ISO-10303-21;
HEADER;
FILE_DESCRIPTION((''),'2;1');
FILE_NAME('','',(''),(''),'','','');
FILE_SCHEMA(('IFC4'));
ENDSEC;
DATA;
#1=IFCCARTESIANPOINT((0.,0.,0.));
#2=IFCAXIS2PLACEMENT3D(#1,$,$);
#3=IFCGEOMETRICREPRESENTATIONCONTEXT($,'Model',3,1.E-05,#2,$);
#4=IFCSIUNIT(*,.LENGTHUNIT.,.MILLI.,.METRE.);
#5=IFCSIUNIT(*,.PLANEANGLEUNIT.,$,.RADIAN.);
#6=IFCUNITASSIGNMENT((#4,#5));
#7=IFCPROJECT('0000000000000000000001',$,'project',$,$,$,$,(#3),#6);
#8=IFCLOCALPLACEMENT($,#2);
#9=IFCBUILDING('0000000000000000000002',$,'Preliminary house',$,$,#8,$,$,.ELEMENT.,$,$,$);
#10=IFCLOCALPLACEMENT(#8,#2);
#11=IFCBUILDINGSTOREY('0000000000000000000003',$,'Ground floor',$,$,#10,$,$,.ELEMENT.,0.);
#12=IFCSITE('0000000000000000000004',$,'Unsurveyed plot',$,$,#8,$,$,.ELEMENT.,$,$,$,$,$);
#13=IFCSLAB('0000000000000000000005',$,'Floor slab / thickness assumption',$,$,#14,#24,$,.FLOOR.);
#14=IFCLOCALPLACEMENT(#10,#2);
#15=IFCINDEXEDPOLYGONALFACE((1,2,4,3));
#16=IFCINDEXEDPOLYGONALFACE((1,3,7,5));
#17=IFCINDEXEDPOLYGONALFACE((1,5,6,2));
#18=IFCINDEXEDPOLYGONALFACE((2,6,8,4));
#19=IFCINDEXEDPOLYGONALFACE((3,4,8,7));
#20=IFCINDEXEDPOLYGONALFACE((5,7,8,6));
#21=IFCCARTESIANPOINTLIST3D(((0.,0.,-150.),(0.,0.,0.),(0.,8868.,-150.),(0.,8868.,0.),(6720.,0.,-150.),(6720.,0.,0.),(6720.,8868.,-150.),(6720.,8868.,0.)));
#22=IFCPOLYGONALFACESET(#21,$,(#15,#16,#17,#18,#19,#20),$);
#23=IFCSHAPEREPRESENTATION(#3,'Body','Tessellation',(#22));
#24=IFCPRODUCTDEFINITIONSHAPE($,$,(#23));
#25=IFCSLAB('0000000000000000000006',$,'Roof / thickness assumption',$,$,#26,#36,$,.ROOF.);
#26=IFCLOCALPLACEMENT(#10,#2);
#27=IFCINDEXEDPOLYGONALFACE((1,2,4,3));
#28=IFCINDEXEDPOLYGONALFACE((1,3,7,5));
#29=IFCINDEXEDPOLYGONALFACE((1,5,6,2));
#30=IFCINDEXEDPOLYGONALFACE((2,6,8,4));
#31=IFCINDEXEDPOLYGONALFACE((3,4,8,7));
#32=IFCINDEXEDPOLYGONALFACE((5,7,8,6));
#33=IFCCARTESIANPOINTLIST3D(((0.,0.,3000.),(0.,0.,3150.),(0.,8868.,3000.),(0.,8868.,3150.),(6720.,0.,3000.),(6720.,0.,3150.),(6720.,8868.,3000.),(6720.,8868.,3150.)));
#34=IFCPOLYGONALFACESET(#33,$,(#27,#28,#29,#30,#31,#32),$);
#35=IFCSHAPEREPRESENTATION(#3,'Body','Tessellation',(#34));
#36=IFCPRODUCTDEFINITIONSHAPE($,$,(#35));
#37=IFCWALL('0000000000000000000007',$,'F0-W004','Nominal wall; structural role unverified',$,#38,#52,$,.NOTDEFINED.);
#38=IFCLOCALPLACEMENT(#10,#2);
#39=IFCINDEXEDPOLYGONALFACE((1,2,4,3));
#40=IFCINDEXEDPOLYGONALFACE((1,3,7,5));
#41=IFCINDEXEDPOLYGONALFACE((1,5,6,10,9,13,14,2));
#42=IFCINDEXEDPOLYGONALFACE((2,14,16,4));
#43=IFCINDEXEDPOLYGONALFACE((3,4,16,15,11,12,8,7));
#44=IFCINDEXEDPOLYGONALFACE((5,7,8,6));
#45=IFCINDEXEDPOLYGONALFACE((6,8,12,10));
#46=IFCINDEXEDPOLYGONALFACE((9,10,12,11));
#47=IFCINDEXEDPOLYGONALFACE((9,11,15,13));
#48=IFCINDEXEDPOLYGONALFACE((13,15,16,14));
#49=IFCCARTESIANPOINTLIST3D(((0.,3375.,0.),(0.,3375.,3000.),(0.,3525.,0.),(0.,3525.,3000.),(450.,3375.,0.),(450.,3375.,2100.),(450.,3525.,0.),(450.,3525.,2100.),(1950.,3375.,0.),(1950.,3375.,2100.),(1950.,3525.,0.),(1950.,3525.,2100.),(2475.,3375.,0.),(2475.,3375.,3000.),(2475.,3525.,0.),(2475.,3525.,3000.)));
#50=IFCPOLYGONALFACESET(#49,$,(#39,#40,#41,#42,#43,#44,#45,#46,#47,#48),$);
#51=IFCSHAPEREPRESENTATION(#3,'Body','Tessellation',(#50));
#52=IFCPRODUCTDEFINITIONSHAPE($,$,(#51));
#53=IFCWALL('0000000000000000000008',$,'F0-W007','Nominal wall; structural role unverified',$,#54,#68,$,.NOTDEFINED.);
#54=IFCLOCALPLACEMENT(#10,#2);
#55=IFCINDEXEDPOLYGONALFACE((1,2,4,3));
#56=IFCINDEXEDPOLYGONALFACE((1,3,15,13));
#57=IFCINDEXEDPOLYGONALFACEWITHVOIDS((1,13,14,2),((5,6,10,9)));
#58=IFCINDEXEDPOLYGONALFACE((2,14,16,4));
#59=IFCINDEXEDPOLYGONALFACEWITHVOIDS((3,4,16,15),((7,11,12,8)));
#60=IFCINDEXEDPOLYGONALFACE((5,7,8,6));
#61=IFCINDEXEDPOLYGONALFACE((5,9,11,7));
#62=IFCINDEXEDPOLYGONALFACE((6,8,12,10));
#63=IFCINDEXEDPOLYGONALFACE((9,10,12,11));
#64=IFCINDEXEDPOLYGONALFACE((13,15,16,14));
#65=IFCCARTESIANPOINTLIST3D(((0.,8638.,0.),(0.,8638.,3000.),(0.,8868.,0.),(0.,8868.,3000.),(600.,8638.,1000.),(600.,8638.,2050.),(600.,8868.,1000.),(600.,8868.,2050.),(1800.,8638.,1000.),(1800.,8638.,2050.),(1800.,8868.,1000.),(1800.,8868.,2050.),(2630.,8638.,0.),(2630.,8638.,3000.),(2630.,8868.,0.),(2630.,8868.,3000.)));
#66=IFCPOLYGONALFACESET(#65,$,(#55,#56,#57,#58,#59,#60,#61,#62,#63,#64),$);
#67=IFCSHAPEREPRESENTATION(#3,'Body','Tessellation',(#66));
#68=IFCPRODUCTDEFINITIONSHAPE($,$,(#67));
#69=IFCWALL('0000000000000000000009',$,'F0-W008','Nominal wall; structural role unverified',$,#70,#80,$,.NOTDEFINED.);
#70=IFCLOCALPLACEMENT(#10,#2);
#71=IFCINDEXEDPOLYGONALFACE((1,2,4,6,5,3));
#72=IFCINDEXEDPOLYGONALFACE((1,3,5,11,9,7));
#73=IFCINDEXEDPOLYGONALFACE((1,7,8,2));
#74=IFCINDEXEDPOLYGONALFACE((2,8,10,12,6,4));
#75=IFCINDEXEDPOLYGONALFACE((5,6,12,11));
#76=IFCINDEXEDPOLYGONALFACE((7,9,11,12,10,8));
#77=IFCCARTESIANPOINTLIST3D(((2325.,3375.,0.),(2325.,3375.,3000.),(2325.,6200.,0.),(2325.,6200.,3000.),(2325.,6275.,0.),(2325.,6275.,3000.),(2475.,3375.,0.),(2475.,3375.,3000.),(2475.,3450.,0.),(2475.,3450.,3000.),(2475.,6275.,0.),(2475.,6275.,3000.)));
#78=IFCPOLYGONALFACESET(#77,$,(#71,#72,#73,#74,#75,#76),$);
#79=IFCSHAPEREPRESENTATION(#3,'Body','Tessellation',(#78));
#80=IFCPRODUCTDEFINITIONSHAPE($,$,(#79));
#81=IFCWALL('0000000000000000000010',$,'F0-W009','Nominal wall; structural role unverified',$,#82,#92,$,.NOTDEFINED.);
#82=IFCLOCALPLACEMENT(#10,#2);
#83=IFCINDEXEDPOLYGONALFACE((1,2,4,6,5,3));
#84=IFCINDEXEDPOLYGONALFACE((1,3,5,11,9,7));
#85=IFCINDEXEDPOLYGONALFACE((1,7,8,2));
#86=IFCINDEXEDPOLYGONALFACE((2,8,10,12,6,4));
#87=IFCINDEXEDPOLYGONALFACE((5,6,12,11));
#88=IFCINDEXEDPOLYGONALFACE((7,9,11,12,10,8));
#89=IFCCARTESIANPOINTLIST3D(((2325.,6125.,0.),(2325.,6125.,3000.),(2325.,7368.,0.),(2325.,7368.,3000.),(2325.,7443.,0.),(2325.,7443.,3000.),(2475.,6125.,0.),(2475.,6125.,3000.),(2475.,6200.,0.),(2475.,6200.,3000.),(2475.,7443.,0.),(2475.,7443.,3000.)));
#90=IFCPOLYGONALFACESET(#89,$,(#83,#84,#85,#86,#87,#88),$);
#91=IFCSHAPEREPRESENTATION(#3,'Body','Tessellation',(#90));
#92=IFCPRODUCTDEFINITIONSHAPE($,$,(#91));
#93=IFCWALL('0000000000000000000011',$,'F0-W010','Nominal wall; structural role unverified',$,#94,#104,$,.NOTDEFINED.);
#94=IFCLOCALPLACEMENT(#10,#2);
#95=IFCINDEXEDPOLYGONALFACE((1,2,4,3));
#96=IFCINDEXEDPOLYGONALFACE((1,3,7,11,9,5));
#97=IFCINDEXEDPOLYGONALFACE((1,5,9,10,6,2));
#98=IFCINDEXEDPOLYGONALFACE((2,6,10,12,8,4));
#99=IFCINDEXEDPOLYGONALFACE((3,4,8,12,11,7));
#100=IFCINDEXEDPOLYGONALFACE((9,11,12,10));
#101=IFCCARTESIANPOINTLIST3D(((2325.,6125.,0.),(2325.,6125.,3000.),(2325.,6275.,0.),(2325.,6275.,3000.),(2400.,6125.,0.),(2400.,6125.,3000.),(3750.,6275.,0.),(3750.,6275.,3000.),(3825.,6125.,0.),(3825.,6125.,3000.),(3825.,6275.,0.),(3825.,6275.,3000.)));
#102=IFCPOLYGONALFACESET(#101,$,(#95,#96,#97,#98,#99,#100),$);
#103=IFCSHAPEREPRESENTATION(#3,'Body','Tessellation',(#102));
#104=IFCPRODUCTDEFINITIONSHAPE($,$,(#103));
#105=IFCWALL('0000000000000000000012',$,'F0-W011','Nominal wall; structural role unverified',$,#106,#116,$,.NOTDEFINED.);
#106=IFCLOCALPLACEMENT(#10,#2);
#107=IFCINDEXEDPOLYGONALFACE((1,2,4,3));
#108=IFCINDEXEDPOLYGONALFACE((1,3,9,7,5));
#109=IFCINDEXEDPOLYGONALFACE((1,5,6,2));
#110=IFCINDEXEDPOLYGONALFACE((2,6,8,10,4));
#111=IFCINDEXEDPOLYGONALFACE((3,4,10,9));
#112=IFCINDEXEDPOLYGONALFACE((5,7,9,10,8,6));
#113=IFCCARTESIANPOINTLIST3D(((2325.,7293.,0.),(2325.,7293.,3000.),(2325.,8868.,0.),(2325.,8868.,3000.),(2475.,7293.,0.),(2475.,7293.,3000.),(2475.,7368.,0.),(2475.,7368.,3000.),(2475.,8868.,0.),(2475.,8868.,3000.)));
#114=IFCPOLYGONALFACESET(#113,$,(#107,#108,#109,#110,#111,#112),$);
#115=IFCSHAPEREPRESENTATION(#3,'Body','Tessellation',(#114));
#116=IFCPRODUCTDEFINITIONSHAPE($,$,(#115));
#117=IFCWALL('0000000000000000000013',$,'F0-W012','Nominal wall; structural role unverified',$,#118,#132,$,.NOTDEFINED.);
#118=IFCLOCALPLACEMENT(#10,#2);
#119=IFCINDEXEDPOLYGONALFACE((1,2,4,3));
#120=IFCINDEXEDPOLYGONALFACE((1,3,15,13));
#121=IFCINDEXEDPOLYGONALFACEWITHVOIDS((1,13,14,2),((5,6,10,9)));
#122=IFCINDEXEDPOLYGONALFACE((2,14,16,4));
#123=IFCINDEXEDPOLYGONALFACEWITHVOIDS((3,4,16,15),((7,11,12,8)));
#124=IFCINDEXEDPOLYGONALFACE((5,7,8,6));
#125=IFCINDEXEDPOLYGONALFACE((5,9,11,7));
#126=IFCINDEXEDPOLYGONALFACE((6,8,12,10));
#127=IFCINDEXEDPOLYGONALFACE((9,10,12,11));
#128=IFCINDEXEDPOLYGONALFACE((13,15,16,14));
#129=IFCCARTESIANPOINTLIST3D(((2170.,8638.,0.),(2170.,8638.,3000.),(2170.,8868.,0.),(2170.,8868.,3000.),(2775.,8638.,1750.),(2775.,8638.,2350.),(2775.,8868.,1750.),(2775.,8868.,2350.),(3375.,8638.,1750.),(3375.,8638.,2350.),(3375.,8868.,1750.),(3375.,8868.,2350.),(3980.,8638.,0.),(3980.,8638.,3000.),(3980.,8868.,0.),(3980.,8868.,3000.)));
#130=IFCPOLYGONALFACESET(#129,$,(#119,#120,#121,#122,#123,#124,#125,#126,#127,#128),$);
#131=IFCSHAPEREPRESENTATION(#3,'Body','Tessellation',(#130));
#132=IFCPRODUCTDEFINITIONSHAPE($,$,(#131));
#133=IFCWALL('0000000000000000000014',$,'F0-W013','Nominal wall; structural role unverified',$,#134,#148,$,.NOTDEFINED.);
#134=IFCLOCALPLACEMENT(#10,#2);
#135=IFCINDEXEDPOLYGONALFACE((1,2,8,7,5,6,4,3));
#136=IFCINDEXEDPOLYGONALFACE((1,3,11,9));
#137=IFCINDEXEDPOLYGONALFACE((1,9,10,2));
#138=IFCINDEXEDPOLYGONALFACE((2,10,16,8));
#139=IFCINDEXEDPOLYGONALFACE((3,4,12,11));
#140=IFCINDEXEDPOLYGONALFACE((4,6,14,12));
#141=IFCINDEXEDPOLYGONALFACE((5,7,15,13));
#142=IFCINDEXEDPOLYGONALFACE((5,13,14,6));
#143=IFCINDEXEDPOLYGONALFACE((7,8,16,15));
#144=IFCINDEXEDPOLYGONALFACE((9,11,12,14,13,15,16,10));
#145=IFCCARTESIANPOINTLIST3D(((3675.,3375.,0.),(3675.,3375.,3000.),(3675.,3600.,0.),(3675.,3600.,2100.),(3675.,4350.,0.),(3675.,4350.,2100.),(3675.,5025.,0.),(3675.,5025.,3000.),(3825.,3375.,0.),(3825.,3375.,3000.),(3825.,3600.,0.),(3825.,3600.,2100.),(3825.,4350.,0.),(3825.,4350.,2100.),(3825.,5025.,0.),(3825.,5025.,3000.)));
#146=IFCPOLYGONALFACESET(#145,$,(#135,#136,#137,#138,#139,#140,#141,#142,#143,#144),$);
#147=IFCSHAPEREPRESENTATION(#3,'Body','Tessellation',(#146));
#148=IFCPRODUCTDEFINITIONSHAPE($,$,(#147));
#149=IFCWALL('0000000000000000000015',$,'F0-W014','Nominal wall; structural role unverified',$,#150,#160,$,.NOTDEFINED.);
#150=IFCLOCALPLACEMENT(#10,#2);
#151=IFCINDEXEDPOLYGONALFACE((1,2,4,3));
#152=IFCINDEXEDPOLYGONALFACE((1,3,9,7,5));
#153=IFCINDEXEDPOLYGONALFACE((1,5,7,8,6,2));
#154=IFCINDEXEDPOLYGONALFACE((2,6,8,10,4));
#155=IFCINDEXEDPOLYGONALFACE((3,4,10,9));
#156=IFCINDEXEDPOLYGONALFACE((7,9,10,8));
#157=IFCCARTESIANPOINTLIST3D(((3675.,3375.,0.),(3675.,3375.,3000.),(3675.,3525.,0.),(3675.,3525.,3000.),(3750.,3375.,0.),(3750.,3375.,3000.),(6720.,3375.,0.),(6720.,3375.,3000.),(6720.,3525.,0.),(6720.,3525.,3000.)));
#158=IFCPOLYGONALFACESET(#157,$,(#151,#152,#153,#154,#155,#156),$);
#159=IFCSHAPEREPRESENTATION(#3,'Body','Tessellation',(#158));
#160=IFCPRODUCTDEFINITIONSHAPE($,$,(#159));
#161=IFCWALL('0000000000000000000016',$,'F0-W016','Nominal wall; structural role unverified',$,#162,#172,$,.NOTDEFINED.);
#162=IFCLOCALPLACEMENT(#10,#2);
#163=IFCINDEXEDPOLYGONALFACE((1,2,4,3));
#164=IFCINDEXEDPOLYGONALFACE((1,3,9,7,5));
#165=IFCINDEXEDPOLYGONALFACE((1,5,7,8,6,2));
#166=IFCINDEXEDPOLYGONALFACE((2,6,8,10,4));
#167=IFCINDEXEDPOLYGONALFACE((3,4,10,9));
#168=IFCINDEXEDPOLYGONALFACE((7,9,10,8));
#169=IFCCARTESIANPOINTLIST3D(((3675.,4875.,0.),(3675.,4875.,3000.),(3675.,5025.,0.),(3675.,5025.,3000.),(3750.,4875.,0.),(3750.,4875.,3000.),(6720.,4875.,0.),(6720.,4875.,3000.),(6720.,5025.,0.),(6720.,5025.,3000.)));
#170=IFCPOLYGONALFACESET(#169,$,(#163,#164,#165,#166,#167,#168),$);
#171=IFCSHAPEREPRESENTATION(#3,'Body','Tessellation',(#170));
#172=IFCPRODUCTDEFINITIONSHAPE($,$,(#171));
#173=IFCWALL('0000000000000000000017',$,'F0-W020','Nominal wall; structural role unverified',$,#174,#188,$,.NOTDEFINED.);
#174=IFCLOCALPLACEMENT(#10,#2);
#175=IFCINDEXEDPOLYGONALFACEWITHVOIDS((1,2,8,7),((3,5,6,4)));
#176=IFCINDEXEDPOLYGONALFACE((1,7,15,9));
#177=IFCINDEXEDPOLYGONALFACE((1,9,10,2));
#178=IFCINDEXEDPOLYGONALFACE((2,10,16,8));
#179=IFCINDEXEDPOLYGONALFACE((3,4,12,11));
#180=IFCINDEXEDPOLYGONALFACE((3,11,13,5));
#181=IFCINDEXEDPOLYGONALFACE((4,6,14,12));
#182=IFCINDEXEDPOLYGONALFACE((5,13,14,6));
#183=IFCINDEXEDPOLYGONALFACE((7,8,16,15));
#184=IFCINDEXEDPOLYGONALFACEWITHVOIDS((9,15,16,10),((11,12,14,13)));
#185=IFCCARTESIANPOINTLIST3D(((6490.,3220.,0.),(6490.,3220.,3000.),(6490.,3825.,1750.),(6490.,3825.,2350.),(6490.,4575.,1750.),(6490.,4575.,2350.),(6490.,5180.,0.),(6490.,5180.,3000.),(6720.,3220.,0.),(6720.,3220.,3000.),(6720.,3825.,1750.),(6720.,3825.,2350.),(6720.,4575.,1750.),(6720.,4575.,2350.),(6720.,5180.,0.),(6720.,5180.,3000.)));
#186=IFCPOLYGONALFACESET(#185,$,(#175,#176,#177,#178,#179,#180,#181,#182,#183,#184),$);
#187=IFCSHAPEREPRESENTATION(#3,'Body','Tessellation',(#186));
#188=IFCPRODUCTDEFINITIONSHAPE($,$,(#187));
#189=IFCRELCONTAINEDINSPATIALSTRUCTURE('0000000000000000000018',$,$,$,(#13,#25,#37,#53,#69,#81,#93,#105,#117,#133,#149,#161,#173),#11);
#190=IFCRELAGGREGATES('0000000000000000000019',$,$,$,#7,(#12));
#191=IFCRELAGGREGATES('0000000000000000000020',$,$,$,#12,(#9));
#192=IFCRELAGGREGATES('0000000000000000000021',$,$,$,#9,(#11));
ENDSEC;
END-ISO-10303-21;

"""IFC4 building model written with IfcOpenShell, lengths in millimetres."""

from ifc_helpers import new_model, si_unit, frame, origin, place, context, project, spatial, polyline, outline, extrude, element, save


model = new_model("IFC4")

# Units and contexts
model_context = context("Model", 3, precision=1e-05, world=origin())
ifc_project = project(units=[si_unit("LENGTHUNIT", "METRE", prefix="MILLI"), si_unit("PLANEANGLEUNIT", "RADIAN")], contexts=[model_context])

# Site, building, storey
placement_1 = place(None, origin())
site = spatial("IfcSite", under=ifc_project, at=placement_1, Name="Unsurveyed plot", CompositionType="ELEMENT")
building = spatial("IfcBuilding", under=site, at=placement_1, Name="Preliminary house", CompositionType="ELEMENT")
placement_2 = place(placement_1, origin())
storey = spatial("IfcBuildingStorey", under=building, at=placement_2, Name="Ground floor", CompositionType="ELEMENT", Elevation=0.0)

# Slabs
element("IfcSlab", 1, at=placement_2, inside=storey, Name="Floor slab / thickness assumption", PredefinedType="FLOOR", context=model_context, shape_type="SweptSolid", body=[
    extrude(outline(polyline([(6720.0, 0.0), (6720.0, 8868.0), (0.0, 8868.0), (0.0, 0.0), (6720.0, 0.0)])), frame((0.0, 0.0, -150.0)), (0.0, 0.0, 1.0), 150.0),
])
element("IfcSlab", 2, at=placement_2, inside=storey, Name="Roof / thickness assumption", PredefinedType="ROOF", context=model_context, shape_type="SweptSolid", body=[
    extrude(outline(polyline([(6720.0, 0.0), (6720.0, 8868.0), (0.0, 8868.0), (0.0, 0.0), (6720.0, 0.0)])), frame((0.0, 0.0, 3000.0)), (0.0, 0.0, 1.0), 150.0),
])

# Walls, openings
wall_1 = element("IfcWall", 3, at=placement_2, inside=storey, Name="F0-W004", Description="Nominal wall; structural role unverified", PredefinedType="NOTDEFINED", context=model_context, shape_type="SweptSolid", body=[
    extrude(outline(polyline([(2475.0, 3525.0), (2475.0, 3375.0), (0.0, 3375.0), (0.0, 3525.0), (2400.0, 3525.0), (2475.0, 3525.0)])), origin(), (0.0, 0.0, 1.0), 3000.0),
])
element("IfcOpeningElement", 4, at=placement_2, cuts=wall_1, PredefinedType="OPENING", context=model_context, shape_type="SweptSolid", body=[
    extrude(outline(polyline([(450.0, 3000.0), (1950.0, 3000.0), (1950.0, 3900.0), (450.0, 3900.0), (450.0, 3000.0)])), origin(), (0.0, 0.0, 1.0), 2100.0),
])
wall_2 = element("IfcWall", 5, at=placement_2, inside=storey, Name="F0-W007", Description="Nominal wall; structural role unverified", PredefinedType="NOTDEFINED", context=model_context, shape_type="SweptSolid", body=[
    extrude(outline(polyline([(2630.0, 8638.0), (0.0, 8638.0), (0.0, 8868.0), (2630.0, 8868.0), (2630.0, 8638.0)])), origin(), (0.0, 0.0, 1.0), 3000.0),
])
element("IfcOpeningElement", 6, at=placement_2, cuts=wall_2, PredefinedType="OPENING", context=model_context, shape_type="SweptSolid", body=[
    extrude(outline(polyline([(600.0, 8223.0), (1800.0, 8223.0), (1800.0, 9283.0), (600.0, 9283.0), (600.0, 8223.0)])), frame((0.0, 0.0, 1000.0)), (0.0, 0.0, 1.0), 1050.0),
])

# Walls
element("IfcWall", 7, at=placement_2, inside=storey, Name="F0-W008", Description="Nominal wall; structural role unverified", PredefinedType="NOTDEFINED", context=model_context, shape_type="SweptSolid", body=[
    extrude(outline(polyline([(2325.0, 6275.0), (2475.0, 6275.0), (2475.0, 3450.0), (2475.0, 3375.0), (2325.0, 3375.0), (2325.0, 6200.0), (2325.0, 6275.0)])), origin(), (0.0, 0.0, 1.0), 3000.0),
])
element("IfcWall", 8, at=placement_2, inside=storey, Name="F0-W009", Description="Nominal wall; structural role unverified", PredefinedType="NOTDEFINED", context=model_context, shape_type="SweptSolid", body=[
    extrude(outline(polyline([(2325.0, 7443.0), (2475.0, 7443.0), (2475.0, 6200.0), (2475.0, 6125.0), (2325.0, 6125.0), (2325.0, 7368.0), (2325.0, 7443.0)])), origin(), (0.0, 0.0, 1.0), 3000.0),
])
element("IfcWall", 9, at=placement_2, inside=storey, Name="F0-W010", Description="Nominal wall; structural role unverified", PredefinedType="NOTDEFINED", context=model_context, shape_type="SweptSolid", body=[
    extrude(outline(polyline([(3825.0, 6275.0), (3825.0, 6125.0), (2400.0, 6125.0), (2325.0, 6125.0), (2325.0, 6275.0), (3750.0, 6275.0), (3825.0, 6275.0)])), origin(), (0.0, 0.0, 1.0), 3000.0),
])
element("IfcWall", 10, at=placement_2, inside=storey, Name="F0-W011", Description="Nominal wall; structural role unverified", PredefinedType="NOTDEFINED", context=model_context, shape_type="SweptSolid", body=[
    extrude(outline(polyline([(2475.0, 7368.0), (2475.0, 7293.0), (2325.0, 7293.0), (2325.0, 8868.0), (2475.0, 8868.0), (2475.0, 7368.0)])), origin(), (0.0, 0.0, 1.0), 3000.0),
])

# Walls, openings
wall_3 = element("IfcWall", 11, at=placement_2, inside=storey, Name="F0-W012", Description="Nominal wall; structural role unverified", PredefinedType="NOTDEFINED", context=model_context, shape_type="SweptSolid", body=[
    extrude(outline(polyline([(3980.0, 8638.0), (2400.0, 8638.0), (2170.0, 8638.0), (2170.0, 8868.0), (3980.0, 8868.0), (3980.0, 8638.0)])), origin(), (0.0, 0.0, 1.0), 3000.0),
])
element("IfcOpeningElement", 12, at=placement_2, cuts=wall_3, PredefinedType="OPENING", context=model_context, shape_type="SweptSolid", body=[
    extrude(outline(polyline([(2775.0, 8223.0), (3375.0, 8223.0), (3375.0, 9283.0), (2775.0, 9283.0), (2775.0, 8223.0)])), frame((0.0, 0.0, 1750.0)), (0.0, 0.0, 1.0), 600.0),
])
wall_4 = element("IfcWall", 13, at=placement_2, inside=storey, Name="F0-W013", Description="Nominal wall; structural role unverified", PredefinedType="NOTDEFINED", context=model_context, shape_type="SweptSolid", body=[
    extrude(outline(polyline([(3675.0, 5025.0), (3825.0, 5025.0), (3825.0, 3450.0), (3825.0, 3375.0), (3675.0, 3375.0), (3675.0, 4950.0), (3675.0, 5025.0)])), origin(), (0.0, 0.0, 1.0), 3000.0),
])
element("IfcOpeningElement", 14, at=placement_2, cuts=wall_4, PredefinedType="OPENING", context=model_context, shape_type="SweptSolid", body=[
    extrude(outline(polyline([(4200.0, 3600.0), (4200.0, 4350.0), (3300.0, 4350.0), (3300.0, 3600.0), (4200.0, 3600.0)])), origin(), (0.0, 0.0, 1.0), 2100.0),
])

# Wall
element("IfcWall", 15, at=placement_2, inside=storey, Name="F0-W014", Description="Nominal wall; structural role unverified", PredefinedType="NOTDEFINED", context=model_context, shape_type="SweptSolid", body=[
    extrude(outline(polyline([(3750.0, 3375.0), (3675.0, 3375.0), (3675.0, 3525.0), (6720.0, 3525.0), (6720.0, 3375.0), (3750.0, 3375.0)])), origin(), (0.0, 0.0, 1.0), 3000.0),
])

# Wall
element("IfcWall", 16, at=placement_2, inside=storey, Name="F0-W016", Description="Nominal wall; structural role unverified", PredefinedType="NOTDEFINED", context=model_context, shape_type="SweptSolid", body=[
    extrude(outline(polyline([(3750.0, 4875.0), (3675.0, 4875.0), (3675.0, 5025.0), (6720.0, 5025.0), (6720.0, 4875.0), (3750.0, 4875.0)])), origin(), (0.0, 0.0, 1.0), 3000.0),
])

# Wall, opening
wall_5 = element("IfcWall", 17, at=placement_2, inside=storey, Name="F0-W020", Description="Nominal wall; structural role unverified", PredefinedType="NOTDEFINED", context=model_context, shape_type="SweptSolid", body=[
    extrude(outline(polyline([(6490.0, 5180.0), (6720.0, 5180.0), (6720.0, 3220.0), (6490.0, 3220.0), (6490.0, 4950.0), (6490.0, 5180.0)])), origin(), (0.0, 0.0, 1.0), 3000.0),
])
element("IfcOpeningElement", 18, at=placement_2, cuts=wall_5, PredefinedType="OPENING", context=model_context, shape_type="SweptSolid", body=[
    extrude(outline(polyline([(7135.0, 3825.0), (7135.0, 4575.0), (6075.0, 4575.0), (6075.0, 3825.0), (7135.0, 3825.0)])), frame((0.0, 0.0, 1750.0)), (0.0, 0.0, 1.0), 600.0),
])

save(model, "model.ifc")
